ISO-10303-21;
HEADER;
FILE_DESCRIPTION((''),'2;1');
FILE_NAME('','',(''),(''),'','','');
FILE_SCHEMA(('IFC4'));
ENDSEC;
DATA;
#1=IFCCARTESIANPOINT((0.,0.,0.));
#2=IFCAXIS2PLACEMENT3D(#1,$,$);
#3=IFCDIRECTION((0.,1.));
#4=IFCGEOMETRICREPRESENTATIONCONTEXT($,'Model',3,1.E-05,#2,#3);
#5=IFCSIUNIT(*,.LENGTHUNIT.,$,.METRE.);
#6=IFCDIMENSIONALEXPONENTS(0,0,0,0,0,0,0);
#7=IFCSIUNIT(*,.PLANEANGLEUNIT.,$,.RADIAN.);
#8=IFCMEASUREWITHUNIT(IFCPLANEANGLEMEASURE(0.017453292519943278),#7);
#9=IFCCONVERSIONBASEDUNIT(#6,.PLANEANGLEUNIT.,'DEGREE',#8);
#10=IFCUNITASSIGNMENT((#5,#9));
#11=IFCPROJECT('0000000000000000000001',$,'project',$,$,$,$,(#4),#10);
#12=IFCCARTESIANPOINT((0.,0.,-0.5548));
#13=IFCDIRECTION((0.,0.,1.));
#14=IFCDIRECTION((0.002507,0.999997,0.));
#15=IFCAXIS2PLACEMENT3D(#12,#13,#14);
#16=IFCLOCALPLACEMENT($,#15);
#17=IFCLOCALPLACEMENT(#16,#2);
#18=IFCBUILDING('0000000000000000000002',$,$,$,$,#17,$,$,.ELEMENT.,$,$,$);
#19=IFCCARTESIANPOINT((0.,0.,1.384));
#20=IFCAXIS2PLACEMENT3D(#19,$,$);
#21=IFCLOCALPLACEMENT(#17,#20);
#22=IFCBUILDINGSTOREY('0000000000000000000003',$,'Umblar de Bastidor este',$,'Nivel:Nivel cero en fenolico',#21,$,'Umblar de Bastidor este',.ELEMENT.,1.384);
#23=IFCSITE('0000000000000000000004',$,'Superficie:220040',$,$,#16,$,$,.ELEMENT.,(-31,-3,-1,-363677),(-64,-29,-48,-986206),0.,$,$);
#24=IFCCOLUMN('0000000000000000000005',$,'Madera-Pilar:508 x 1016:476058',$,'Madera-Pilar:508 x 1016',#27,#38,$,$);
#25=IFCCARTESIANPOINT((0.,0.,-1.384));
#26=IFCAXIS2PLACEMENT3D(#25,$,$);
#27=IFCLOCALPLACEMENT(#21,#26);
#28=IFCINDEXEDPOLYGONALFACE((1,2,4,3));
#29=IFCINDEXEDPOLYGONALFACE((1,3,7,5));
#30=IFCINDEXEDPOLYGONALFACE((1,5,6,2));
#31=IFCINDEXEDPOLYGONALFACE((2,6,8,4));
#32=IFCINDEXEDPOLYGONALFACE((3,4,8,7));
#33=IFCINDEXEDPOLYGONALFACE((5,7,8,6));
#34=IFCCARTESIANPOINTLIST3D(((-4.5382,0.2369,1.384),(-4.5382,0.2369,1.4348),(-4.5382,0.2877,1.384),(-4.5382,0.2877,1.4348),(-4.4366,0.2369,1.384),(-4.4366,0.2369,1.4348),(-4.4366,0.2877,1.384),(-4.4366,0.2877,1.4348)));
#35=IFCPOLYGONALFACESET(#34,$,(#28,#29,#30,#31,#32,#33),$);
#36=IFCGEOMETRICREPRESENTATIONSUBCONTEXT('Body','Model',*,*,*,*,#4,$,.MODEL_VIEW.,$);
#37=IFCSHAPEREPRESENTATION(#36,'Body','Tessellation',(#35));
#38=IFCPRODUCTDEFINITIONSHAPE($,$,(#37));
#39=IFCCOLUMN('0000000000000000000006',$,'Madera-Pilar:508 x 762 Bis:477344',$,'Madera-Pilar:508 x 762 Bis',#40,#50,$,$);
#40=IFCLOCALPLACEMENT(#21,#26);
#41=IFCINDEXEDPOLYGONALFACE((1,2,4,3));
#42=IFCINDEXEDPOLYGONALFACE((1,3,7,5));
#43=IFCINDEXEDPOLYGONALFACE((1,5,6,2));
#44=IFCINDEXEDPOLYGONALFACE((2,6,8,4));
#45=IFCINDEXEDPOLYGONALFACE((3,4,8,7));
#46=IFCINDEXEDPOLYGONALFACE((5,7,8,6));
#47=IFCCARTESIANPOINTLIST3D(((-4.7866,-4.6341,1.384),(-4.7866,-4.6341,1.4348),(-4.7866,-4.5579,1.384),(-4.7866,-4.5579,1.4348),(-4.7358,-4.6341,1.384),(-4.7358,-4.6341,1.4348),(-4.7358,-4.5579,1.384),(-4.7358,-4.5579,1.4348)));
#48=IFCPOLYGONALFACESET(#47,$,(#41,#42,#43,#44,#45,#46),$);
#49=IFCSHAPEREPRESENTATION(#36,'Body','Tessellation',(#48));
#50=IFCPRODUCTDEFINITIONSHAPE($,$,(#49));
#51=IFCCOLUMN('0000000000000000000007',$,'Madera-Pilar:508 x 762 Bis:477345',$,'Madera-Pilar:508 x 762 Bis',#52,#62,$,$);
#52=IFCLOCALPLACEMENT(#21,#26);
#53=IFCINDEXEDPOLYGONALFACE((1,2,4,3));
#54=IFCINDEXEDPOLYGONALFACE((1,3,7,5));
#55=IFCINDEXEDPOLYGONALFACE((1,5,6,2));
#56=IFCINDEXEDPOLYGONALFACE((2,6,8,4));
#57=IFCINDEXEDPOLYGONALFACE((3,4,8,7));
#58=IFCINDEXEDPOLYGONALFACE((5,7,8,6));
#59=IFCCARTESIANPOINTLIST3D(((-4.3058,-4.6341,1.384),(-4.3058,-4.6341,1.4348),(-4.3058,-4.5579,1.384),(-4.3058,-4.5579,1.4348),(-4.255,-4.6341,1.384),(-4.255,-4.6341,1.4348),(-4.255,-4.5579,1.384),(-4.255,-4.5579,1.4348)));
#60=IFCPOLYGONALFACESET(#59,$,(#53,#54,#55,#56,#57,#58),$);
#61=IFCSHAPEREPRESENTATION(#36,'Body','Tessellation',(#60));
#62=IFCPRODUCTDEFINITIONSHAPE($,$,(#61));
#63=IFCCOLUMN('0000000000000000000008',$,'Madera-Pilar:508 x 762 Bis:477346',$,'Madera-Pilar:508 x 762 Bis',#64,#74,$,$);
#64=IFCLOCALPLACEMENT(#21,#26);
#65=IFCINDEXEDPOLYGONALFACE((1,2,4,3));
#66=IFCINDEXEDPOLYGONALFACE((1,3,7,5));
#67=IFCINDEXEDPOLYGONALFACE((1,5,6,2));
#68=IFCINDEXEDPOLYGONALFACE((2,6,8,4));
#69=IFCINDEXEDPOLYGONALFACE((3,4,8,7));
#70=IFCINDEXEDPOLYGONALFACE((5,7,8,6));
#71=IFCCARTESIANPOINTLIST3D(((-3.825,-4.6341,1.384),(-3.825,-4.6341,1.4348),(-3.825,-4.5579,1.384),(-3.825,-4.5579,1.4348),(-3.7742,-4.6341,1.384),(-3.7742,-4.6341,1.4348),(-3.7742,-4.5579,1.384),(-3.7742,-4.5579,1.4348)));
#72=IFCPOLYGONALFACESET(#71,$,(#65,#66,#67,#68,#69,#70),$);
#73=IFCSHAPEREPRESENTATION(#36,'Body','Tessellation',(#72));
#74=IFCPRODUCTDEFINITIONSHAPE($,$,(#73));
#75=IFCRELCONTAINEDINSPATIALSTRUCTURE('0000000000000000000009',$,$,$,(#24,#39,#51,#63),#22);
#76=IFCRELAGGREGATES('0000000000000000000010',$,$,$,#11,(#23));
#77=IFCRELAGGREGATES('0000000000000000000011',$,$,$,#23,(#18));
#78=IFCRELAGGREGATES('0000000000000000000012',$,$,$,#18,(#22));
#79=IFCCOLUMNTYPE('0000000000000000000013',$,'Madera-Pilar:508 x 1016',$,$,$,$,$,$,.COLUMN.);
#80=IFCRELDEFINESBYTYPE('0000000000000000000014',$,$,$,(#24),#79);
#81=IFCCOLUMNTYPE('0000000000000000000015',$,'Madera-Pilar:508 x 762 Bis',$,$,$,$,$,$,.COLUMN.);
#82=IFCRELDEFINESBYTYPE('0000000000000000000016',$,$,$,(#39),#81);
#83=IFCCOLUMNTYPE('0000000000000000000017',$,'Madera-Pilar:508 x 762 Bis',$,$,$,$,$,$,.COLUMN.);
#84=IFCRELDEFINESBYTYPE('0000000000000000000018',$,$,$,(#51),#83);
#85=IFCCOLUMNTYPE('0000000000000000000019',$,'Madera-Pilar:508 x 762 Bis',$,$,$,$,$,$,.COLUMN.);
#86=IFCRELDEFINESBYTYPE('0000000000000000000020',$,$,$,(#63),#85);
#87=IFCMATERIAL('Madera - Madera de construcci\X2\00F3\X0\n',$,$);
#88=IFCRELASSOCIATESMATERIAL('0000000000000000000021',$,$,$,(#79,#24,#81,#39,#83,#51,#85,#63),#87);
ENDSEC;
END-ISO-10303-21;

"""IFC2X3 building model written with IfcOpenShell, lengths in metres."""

from ifc_helpers import new_model, entity, si_unit, converted_unit, direction, frame, frame_2d, origin, place, context, subcontext, project, spatial, rectangle, extrude, source, transform, mapped, material, type_object, type_shapes, element, save


model = new_model("IFC2X3")

# Units and contexts
model_context = context("Model", 3, precision=1e-05, world=origin(), true_north=direction((0.0, 1.0)))
body_context = subcontext(model_context, "Body", "Model", "MODEL_VIEW")
ifc_project = project(units=[si_unit("LENGTHUNIT", "METRE"), converted_unit("PLANEANGLEUNIT", "DEGREE", entity("IfcPlaneAngleMeasure", 0.017453292519943278), si_unit("PLANEANGLEUNIT", "RADIAN"), dimensions=[0, 0, 0, 0, 0, 0, 0])], contexts=[model_context])

# Site, building, storey
site_placement = place(None, frame((0.0, 0.0, -0.5548), z_axis=(0.0, 0.0, 1.0), x_axis=(0.002507, 0.999997, 0.0)))
site = spatial("IfcSite", under=ifc_project, at=site_placement, Name="Superficie:220040", CompositionType="ELEMENT", RefLatitude=(-31, -3, -1, -363677), RefLongitude=(-64, -29, -48, -986206), RefElevation=0.0)
building_placement = place(site_placement, origin())
building = spatial("IfcBuilding", under=site, at=building_placement, CompositionType="ELEMENT")
storey_placement = place(building_placement, frame((0.0, 0.0, 1.384)))
storey = spatial("IfcBuildingStorey", under=building, at=storey_placement, Name="Umblar de Bastidor este", ObjectType="Nivel:Nivel cero en fenolico", LongName="Umblar de Bastidor este", CompositionType="ELEMENT", Elevation=1.384)

# Columns
ifc_material = material(Name="Madera - Madera de construcción")
column_type_1 = type_object("IfcColumnType", Name="Madera-Pilar:508 x 1016", PredefinedType="COLUMN", material=ifc_material)
shared_shape_1 = source(origin(), body_context, "Body", "SweptSolid", [
    extrude(rectangle(XDim=0.1016, YDim=0.0508, at=frame_2d((0.0, 0.0), x_axis=(1.0, 0.0))), frame((-4.4874, 0.2623, 1.384), z_axis=(0.0, 0.0, 1.0), x_axis=(-1.0, 0.0, 0.0)), (0.0, 0.0, 1.0), 0.0508),
])
type_shapes(column_type_1, [shared_shape_1])
column_1_placement = place(storey_placement, frame((0.0, 0.0, -1.384)))
element("IfcColumn", 1, at=column_1_placement, inside=storey, type_object=column_type_1, material=ifc_material, Name="Madera-Pilar:508 x 1016:476058", ObjectType="Madera-Pilar:508 x 1016", context=body_context, shape_type="MappedRepresentation", body=[
    mapped(shared_shape_1, transform((0.0, 0.0, 0.0), scale=1.0)),
])
column_type_2 = type_object("IfcColumnType", Name="Madera-Pilar:508 x 762 Bis", PredefinedType="COLUMN", material=ifc_material)
shared_shape_2 = source(origin(), body_context, "Body", "SweptSolid", [
    extrude(rectangle(XDim=0.0508, YDim=0.0762, at=frame_2d((0.0, 0.0), x_axis=(1.0, 0.0))), frame((-4.7612, -4.596, 1.384)), (0.0, 0.0, 1.0), 0.0508),
])
type_shapes(column_type_2, [shared_shape_2])
column_2_placement = place(storey_placement, frame((0.0, 0.0, -1.384)))
element("IfcColumn", 2, at=column_2_placement, inside=storey, type_object=column_type_2, material=ifc_material, Name="Madera-Pilar:508 x 762 Bis:477344", ObjectType="Madera-Pilar:508 x 762 Bis", context=body_context, shape_type="MappedRepresentation", body=[
    mapped(shared_shape_2, transform((0.0, 0.0, 0.0), scale=1.0)),
])
column_type_3 = type_object("IfcColumnType", Name="Madera-Pilar:508 x 762 Bis", PredefinedType="COLUMN", material=ifc_material)
shared_shape_3 = source(origin(), body_context, "Body", "SweptSolid", [
    extrude(rectangle(XDim=0.0508, YDim=0.0762, at=frame_2d((0.0, 0.0), x_axis=(1.0, 0.0))), frame((-4.2804, -4.596, 1.384)), (0.0, 0.0, 1.0), 0.0508),
])
type_shapes(column_type_3, [shared_shape_3])
column_3_placement = place(storey_placement, frame((0.0, 0.0, -1.384)))
element("IfcColumn", 3, at=column_3_placement, inside=storey, type_object=column_type_3, material=ifc_material, Name="Madera-Pilar:508 x 762 Bis:477345", ObjectType="Madera-Pilar:508 x 762 Bis", context=body_context, shape_type="MappedRepresentation", body=[
    mapped(shared_shape_3, transform((0.0, 0.0, 0.0), scale=1.0)),
])
column_type_4 = type_object("IfcColumnType", Name="Madera-Pilar:508 x 762 Bis", PredefinedType="COLUMN", material=ifc_material)
shared_shape_4 = source(origin(), body_context, "Body", "SweptSolid", [
    extrude(rectangle(XDim=0.0508, YDim=0.0762, at=frame_2d((0.0, 0.0), x_axis=(1.0, 0.0))), frame((-3.7996, -4.596, 1.384)), (0.0, 0.0, 1.0), 0.0508),
])
type_shapes(column_type_4, [shared_shape_4])
column_4_placement = place(storey_placement, frame((0.0, 0.0, -1.384)))
element("IfcColumn", 4, at=column_4_placement, inside=storey, type_object=column_type_4, material=ifc_material, Name="Madera-Pilar:508 x 762 Bis:477346", ObjectType="Madera-Pilar:508 x 762 Bis", context=body_context, shape_type="MappedRepresentation", body=[
    mapped(shared_shape_4, transform((0.0, 0.0, 0.0), scale=1.0)),
])

save(model, "model.ifc")
